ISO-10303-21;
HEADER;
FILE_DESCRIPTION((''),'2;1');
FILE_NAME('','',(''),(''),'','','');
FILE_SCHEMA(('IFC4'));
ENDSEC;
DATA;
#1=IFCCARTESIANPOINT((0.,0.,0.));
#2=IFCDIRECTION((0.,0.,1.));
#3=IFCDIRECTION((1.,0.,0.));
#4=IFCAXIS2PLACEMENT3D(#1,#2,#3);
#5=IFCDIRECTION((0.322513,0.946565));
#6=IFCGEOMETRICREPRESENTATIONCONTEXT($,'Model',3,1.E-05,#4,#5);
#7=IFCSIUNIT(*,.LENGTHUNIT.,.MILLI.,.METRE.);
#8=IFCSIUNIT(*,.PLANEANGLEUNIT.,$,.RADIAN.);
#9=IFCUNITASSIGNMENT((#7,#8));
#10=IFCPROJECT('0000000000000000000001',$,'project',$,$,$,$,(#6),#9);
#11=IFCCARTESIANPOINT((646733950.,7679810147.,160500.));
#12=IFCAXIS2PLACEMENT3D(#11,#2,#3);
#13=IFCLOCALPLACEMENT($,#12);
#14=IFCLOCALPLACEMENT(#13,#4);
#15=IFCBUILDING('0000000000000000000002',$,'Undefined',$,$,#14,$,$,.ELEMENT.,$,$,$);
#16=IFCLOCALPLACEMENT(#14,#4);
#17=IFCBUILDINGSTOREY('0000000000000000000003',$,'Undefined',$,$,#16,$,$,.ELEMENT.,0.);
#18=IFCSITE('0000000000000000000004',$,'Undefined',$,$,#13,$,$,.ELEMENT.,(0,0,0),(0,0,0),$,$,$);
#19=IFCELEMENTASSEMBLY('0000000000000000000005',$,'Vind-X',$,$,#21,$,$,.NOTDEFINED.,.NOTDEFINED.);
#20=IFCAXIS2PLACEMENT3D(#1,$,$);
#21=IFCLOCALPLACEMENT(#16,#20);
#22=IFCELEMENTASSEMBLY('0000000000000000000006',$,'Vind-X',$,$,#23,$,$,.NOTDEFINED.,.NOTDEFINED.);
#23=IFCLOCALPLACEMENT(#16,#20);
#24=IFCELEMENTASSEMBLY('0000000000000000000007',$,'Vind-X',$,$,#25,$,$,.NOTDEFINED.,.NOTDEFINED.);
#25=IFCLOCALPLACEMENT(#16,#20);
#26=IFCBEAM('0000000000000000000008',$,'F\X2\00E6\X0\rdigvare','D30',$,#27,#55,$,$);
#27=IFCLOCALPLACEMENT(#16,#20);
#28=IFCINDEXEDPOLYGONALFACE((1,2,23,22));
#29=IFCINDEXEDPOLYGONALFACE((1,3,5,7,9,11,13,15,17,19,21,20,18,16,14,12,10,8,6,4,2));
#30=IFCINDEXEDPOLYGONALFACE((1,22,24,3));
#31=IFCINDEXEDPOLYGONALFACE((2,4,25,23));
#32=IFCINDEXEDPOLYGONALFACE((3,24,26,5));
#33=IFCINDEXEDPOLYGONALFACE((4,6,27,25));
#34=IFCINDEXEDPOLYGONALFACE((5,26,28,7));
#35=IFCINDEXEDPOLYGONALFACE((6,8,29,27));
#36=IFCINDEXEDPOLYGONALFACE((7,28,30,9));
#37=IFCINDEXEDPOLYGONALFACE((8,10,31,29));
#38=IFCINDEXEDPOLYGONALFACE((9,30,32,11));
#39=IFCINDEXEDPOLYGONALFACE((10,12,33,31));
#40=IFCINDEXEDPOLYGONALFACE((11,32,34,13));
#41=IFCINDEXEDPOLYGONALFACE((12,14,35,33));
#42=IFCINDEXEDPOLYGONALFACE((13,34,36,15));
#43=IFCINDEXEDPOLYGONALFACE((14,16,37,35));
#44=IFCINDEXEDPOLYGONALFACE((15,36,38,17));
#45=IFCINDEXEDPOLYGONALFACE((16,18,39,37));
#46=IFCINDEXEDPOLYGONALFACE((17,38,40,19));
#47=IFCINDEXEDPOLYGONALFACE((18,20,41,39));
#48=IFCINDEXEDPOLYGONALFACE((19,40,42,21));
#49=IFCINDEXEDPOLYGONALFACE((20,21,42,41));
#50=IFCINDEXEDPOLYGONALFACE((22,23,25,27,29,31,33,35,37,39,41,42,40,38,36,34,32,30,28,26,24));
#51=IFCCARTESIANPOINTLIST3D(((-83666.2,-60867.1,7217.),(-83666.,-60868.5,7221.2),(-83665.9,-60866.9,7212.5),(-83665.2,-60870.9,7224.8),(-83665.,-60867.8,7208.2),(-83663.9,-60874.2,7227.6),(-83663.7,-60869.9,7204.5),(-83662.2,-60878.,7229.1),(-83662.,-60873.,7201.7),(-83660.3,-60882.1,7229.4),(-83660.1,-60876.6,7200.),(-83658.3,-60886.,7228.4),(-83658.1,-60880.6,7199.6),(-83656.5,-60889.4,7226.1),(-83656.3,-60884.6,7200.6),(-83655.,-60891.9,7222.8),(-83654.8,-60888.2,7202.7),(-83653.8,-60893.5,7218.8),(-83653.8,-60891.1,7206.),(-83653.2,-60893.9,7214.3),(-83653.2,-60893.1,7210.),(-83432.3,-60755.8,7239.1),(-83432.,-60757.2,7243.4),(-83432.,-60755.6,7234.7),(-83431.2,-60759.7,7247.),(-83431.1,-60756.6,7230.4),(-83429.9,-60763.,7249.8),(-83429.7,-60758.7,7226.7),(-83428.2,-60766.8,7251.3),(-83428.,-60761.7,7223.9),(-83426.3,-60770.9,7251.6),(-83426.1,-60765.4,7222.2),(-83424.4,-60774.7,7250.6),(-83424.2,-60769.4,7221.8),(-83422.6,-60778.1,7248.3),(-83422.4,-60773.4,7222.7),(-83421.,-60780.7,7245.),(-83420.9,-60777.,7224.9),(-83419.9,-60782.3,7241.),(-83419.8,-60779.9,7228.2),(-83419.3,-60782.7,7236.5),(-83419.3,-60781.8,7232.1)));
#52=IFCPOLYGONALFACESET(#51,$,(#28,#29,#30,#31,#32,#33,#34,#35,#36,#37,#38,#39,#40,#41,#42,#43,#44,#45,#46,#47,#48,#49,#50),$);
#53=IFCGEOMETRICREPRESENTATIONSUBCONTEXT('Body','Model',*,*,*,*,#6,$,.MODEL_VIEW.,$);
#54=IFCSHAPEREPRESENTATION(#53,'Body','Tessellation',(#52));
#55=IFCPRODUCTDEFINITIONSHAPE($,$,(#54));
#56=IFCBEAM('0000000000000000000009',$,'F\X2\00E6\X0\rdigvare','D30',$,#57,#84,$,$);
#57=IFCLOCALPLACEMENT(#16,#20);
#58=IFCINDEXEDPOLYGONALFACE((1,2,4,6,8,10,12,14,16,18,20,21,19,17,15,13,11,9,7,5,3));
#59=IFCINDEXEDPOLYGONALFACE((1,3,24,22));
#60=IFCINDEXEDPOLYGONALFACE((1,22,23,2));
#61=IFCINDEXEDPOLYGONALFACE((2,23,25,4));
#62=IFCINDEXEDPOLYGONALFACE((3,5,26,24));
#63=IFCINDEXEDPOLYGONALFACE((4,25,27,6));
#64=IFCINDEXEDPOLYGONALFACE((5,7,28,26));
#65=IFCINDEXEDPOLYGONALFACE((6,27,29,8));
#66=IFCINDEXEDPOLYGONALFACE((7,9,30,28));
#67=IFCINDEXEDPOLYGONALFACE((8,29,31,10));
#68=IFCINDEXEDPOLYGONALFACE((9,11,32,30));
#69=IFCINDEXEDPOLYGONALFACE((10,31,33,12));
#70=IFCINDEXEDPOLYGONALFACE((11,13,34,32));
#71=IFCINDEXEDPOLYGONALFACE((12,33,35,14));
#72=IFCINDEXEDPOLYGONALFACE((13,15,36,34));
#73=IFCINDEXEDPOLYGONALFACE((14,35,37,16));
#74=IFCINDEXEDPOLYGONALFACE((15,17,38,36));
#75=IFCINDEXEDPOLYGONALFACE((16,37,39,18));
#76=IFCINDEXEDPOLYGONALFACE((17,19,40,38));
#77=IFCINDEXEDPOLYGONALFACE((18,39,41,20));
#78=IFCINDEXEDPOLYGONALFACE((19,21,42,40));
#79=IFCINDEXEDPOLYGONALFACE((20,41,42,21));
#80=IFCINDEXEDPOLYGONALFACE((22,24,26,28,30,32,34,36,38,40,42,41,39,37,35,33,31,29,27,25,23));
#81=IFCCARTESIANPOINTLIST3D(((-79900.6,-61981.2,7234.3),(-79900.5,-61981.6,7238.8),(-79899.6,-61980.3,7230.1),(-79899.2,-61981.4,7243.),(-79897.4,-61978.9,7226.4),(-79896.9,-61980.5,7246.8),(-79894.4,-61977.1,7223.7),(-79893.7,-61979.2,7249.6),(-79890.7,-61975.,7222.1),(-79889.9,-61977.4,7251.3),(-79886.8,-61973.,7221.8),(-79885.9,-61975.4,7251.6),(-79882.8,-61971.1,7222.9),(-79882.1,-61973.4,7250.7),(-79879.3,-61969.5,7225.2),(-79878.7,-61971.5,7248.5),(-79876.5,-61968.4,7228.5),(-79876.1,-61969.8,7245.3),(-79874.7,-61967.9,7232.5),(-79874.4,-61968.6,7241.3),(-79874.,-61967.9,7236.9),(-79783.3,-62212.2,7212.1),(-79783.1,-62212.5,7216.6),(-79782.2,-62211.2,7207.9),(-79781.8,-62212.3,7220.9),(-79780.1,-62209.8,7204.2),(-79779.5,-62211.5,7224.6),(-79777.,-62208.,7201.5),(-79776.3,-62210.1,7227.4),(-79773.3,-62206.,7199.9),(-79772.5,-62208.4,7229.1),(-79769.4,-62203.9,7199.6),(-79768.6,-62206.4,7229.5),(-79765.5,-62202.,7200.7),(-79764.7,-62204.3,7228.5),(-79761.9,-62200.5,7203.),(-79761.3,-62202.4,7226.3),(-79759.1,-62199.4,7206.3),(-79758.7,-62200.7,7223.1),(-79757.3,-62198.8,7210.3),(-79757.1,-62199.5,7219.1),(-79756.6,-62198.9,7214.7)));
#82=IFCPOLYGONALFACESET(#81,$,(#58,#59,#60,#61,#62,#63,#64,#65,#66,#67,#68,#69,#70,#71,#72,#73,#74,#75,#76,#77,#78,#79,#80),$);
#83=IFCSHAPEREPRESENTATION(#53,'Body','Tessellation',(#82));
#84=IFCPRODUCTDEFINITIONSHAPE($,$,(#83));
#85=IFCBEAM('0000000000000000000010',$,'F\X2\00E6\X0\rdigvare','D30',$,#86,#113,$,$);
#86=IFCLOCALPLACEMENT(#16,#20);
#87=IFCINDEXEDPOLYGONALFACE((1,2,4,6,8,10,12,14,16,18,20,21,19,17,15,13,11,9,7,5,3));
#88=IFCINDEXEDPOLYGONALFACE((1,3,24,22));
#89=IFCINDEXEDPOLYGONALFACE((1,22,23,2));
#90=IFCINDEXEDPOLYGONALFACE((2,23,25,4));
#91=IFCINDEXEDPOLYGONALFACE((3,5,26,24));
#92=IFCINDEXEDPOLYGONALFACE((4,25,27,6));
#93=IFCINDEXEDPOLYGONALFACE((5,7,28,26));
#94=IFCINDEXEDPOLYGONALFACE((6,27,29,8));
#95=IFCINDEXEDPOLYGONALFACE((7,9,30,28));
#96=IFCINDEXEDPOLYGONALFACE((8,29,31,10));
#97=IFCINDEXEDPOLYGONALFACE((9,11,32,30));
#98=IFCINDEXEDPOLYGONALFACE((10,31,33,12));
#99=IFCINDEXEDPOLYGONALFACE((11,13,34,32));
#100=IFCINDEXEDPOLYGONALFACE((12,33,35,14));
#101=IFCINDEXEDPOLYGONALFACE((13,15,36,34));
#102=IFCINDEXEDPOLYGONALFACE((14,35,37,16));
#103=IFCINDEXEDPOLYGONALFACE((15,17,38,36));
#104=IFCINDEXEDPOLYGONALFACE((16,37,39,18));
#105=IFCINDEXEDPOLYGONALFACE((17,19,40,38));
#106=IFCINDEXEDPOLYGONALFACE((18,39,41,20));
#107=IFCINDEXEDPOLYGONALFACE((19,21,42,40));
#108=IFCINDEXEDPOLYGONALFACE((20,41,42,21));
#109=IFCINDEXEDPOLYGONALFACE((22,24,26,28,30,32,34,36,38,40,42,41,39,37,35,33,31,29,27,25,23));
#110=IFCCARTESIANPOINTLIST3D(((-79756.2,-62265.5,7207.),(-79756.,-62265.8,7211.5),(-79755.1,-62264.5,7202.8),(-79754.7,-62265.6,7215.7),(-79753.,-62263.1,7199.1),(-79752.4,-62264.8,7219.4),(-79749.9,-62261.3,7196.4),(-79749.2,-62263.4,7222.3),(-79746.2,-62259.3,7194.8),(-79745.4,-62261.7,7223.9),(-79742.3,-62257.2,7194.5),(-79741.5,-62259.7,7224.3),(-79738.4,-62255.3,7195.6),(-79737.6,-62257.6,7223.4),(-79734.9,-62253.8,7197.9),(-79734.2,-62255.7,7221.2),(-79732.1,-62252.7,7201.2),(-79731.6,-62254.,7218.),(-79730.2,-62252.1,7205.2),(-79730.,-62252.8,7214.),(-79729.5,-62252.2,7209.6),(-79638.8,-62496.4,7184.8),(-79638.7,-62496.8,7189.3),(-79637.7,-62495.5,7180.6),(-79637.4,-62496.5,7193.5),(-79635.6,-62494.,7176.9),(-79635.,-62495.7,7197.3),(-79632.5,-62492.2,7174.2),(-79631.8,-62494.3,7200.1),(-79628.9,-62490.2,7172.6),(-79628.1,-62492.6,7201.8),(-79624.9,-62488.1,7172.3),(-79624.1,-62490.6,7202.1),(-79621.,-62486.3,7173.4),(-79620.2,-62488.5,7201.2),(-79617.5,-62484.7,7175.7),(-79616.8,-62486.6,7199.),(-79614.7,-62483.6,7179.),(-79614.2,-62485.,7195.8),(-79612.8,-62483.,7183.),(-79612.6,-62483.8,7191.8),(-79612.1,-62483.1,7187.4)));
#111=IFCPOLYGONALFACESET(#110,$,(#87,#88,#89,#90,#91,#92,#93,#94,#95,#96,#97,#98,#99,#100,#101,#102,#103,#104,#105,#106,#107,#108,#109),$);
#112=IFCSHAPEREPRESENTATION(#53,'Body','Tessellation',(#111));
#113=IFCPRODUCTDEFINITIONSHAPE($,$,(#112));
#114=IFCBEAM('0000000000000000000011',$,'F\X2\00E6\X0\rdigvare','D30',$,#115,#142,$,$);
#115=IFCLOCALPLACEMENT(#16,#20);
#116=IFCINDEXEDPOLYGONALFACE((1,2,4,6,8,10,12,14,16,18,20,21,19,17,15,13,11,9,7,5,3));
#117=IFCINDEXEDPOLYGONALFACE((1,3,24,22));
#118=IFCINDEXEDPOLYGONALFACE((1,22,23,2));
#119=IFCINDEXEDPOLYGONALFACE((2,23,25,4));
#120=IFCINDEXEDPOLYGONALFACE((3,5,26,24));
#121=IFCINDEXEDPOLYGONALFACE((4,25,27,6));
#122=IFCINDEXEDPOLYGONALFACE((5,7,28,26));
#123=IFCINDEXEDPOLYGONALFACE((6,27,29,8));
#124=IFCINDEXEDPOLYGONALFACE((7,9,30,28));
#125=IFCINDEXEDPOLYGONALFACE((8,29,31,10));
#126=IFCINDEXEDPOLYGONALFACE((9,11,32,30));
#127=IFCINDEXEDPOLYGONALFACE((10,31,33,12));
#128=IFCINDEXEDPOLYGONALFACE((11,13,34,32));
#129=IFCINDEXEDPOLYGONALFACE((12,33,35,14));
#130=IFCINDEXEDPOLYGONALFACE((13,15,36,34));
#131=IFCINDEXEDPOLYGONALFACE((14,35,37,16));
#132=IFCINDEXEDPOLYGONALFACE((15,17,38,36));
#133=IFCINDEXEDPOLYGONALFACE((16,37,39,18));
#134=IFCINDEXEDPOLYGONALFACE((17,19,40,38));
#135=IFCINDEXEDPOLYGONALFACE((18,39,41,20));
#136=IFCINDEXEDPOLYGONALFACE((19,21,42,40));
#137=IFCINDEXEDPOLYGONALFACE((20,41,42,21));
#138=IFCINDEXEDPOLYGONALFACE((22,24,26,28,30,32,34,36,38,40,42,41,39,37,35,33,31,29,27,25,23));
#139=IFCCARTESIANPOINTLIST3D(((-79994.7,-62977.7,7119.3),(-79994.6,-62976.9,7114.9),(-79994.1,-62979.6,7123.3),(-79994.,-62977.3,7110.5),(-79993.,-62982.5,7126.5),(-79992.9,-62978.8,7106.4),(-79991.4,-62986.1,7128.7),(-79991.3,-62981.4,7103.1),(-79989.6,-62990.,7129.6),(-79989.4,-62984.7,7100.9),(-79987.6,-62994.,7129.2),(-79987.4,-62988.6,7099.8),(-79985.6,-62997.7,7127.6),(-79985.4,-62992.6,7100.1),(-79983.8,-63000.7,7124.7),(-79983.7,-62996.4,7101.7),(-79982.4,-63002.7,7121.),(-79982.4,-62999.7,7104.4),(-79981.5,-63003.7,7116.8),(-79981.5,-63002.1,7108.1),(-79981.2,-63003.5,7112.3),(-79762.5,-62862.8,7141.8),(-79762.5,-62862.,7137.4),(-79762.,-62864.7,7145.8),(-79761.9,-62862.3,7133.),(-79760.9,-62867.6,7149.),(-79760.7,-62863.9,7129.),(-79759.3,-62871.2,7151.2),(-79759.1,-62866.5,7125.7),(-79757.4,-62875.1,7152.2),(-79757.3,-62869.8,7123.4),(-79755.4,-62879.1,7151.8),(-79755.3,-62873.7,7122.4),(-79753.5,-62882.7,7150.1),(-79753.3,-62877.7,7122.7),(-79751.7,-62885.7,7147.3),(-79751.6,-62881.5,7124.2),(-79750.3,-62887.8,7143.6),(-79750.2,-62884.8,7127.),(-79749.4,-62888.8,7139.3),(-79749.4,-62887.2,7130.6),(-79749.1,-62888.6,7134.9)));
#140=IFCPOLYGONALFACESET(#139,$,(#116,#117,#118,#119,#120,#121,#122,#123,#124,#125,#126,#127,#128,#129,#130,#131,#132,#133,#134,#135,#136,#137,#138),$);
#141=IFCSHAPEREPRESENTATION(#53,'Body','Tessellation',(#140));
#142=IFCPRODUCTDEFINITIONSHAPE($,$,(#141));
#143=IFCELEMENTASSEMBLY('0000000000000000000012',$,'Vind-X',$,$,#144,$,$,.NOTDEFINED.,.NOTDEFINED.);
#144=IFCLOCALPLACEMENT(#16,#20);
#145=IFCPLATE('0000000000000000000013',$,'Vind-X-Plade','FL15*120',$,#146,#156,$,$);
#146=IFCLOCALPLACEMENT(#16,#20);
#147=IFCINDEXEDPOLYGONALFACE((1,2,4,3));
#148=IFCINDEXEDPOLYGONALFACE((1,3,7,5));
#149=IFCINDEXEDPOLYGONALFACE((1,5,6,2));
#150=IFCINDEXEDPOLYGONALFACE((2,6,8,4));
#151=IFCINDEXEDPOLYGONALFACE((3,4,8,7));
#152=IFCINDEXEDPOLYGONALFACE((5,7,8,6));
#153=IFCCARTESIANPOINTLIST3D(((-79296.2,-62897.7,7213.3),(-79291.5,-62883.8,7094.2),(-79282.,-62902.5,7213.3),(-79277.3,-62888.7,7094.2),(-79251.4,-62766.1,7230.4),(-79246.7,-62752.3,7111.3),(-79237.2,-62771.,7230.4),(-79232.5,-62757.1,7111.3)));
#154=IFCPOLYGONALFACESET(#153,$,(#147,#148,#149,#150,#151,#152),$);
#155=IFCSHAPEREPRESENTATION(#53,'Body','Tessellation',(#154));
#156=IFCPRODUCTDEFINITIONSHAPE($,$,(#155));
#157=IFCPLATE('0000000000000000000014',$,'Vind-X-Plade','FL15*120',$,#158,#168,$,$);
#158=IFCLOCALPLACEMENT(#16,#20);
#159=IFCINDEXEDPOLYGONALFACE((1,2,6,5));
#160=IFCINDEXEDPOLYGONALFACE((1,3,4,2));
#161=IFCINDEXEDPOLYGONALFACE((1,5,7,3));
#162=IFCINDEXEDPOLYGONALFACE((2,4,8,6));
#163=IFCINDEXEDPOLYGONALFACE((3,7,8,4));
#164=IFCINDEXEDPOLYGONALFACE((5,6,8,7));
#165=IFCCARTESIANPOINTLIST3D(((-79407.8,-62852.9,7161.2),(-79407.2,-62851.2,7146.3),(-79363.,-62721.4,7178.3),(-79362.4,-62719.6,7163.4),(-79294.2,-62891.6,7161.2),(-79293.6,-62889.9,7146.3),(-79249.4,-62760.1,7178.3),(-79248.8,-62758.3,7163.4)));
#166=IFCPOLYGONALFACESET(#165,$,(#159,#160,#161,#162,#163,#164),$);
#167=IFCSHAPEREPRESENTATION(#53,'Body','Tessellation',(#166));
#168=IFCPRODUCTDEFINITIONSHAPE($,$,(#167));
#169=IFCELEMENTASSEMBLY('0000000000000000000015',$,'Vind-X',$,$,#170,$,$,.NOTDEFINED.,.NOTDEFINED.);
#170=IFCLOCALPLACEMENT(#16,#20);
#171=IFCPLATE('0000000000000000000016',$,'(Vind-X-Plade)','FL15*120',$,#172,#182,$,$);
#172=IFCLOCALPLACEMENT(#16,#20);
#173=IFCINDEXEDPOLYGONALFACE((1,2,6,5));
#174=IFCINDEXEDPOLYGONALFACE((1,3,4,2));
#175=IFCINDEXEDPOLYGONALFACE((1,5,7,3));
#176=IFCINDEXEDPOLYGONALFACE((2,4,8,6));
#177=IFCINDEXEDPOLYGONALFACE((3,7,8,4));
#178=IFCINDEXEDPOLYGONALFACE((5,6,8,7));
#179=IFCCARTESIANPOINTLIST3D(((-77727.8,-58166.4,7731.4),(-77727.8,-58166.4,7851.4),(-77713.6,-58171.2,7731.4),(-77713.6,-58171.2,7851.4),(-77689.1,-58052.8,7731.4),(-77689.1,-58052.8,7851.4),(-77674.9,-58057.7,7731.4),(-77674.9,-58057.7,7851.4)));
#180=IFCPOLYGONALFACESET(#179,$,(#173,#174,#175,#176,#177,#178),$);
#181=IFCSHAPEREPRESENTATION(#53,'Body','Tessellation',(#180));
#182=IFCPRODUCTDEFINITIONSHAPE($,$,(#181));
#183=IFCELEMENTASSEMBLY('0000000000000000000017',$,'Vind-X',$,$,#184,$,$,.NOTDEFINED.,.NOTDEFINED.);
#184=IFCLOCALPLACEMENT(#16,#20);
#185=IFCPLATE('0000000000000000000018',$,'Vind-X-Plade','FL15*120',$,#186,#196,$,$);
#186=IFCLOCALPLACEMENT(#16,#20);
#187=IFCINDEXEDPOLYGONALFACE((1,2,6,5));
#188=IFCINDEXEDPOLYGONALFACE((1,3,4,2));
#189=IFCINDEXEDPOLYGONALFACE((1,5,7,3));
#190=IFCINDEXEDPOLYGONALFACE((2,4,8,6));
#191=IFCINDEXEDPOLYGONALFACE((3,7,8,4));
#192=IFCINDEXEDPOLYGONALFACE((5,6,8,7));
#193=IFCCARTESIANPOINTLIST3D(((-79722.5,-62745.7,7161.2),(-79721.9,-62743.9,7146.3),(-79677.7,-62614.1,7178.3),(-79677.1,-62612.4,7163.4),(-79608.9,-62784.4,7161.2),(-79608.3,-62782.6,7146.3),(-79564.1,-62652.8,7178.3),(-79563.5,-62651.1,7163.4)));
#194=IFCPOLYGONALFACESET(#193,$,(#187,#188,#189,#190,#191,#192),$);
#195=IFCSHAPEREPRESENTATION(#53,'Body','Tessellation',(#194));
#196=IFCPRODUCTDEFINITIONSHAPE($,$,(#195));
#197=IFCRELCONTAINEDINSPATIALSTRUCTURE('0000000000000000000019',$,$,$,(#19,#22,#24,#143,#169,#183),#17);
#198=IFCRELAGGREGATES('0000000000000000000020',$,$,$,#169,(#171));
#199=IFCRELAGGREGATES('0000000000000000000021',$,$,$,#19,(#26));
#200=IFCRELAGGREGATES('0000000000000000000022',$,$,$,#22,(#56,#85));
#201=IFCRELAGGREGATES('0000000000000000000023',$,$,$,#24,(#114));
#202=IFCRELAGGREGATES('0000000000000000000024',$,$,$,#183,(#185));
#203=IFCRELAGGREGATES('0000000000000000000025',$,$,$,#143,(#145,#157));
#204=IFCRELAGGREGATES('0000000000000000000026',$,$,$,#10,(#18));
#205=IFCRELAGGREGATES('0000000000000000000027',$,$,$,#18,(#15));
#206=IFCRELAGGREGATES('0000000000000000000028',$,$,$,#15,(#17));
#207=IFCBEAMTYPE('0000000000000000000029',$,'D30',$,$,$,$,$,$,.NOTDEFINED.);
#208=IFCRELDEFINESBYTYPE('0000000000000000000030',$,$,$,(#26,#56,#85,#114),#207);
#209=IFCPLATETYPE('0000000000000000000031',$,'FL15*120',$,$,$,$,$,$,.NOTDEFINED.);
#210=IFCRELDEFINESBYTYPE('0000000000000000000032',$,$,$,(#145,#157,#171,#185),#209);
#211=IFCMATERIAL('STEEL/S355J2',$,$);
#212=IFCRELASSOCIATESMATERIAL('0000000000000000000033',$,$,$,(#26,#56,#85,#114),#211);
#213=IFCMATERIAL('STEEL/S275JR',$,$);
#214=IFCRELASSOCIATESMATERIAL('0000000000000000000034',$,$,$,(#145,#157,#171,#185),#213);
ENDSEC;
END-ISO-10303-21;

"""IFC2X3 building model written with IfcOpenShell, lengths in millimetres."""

from ifc_helpers import new_model, si_unit, direction, frame, origin_with_axes, origin_2d_with_axis, place, context, subcontext, project, spatial, polyline, circle, outline, extrude, material, type_object, element, aggregate, save


model = new_model("IFC2X3")

# Units and contexts
model_context = context("Model", 3, precision=1e-05, world=origin_with_axes(), true_north=direction((0.322513, 0.946565)))
body_context = subcontext(model_context, "Body", "Model", "MODEL_VIEW")
ifc_project = project(units=[si_unit("LENGTHUNIT", "METRE", prefix="MILLI"), si_unit("PLANEANGLEUNIT", "RADIAN")], contexts=[model_context])

# Site, building, storey
site_placement = place(None, frame((646733950.0, 7679810147.0, 160500.0), z_axis=(0.0, 0.0, 1.0), x_axis=(1.0, 0.0, 0.0)))
site = spatial("IfcSite", under=ifc_project, at=site_placement, Name="Undefined", CompositionType="ELEMENT", RefLatitude=(0, 0, 0), RefLongitude=(0, 0, 0))
building_placement = place(site_placement, origin_with_axes())
building = spatial("IfcBuilding", under=site, at=building_placement, Name="Undefined", CompositionType="ELEMENT")
storey_placement = place(building_placement, origin_with_axes())
storey = spatial("IfcBuildingStorey", under=building, at=storey_placement, Name="Undefined", CompositionType="ELEMENT", Elevation=0.0)

# Element assemblies
assembly_1_placement = place(storey_placement, origin_with_axes())
assembly_1 = element("IfcElementAssembly", 1, at=assembly_1_placement, inside=storey, Name="Vind-X", AssemblyPlace="NOTDEFINED", PredefinedType="NOTDEFINED")
ifc_material_1 = material(Name="STEEL/S355J2")
assembly_2_placement = place(storey_placement, origin_with_axes())
assembly_2 = element("IfcElementAssembly", 2, at=assembly_2_placement, inside=storey, Name="Vind-X", AssemblyPlace="NOTDEFINED", PredefinedType="NOTDEFINED")

# Element assembly
assembly_3_placement = place(storey_placement, origin_with_axes())
assembly_3 = element("IfcElementAssembly", 3, at=assembly_3_placement, inside=storey, Name="Vind-X", AssemblyPlace="NOTDEFINED", PredefinedType="NOTDEFINED")

# Beams
beam_type_1 = type_object("IfcBeamType", Name="D30", PredefinedType="NOTDEFINED")
beam_1_placement = place(assembly_1_placement, frame((-83659.7, -60880.3, 7214.5), z_axis=(-0.434441, 0.89649, 0.08699), x_axis=(0.899842, 0.427784, 0.085352)))
beam_1 = element("IfcBeam", 4, at=beam_1_placement, type_object=beam_type_1, material=ifc_material_1, Name="Færdigvare", Description="D30", context=body_context, shape_type="SweptSolid", body=[
    extrude(circle(Radius=15.0, at=origin_2d_with_axis()), frame((260.0, 0.0, 0.0), z_axis=(-1.0, 0.0, 0.0), x_axis=(0.0, -1.0, 0.0)), (0.0, 0.0, 1.0), 260.0),
])
beam_2_placement = place(assembly_2_placement, frame((-79770.0, -62205.7, 7214.5), z_axis=(0.891425, 0.444742, 0.08699), x_axis=(-0.451461, 0.888199, 0.085352)))
beam_2 = element("IfcBeam", 5, at=beam_2_placement, type_object=beam_type_1, material=ifc_material_1, Name="Færdigvare", Description="D30", context=body_context, shape_type="SweptSolid", body=[
    extrude(circle(Radius=15.0, at=origin_2d_with_axis()), frame((260.0, 0.0, 0.0), z_axis=(-1.0, 0.0, 0.0), x_axis=(0.0, -1.0, 0.0)), (0.0, 0.0, 1.0), 260.0),
])
beam_3_placement = place(assembly_2_placement, frame((-79625.5, -62489.9, 7187.2), z_axis=(0.891424, 0.444742, 0.08699), x_axis=(-0.451462, 0.888199, 0.085352)))
beam_3 = element("IfcBeam", 6, at=beam_3_placement, type_object=beam_type_1, material=ifc_material_1, Name="Færdigvare", Description="D30", context=body_context, shape_type="SweptSolid", body=[
    extrude(circle(Radius=15.0, at=origin_2d_with_axis()), frame((260.0, 0.0, 0.0), z_axis=(-1.0, 0.0, 0.0), x_axis=(0.0, -1.0, 0.0)), (0.0, 0.0, 1.0), 260.0),
])
beam_4_placement = place(assembly_3_placement, frame((-79755.8, -62875.4, 7137.3), z_axis=(-0.448662, 0.88959, 0.085625), x_axis=(-0.892837, -0.441952, -0.086721)))
beam_4 = element("IfcBeam", 7, at=beam_4_placement, type_object=beam_type_1, material=ifc_material_1, Name="Færdigvare", Description="D30", context=body_context, shape_type="SweptSolid", body=[
    extrude(circle(Radius=15.0, at=origin_2d_with_axis()), frame((260.0, 0.0, 0.0), z_axis=(-1.0, 0.0, 0.0), x_axis=(0.0, -1.0, 0.0)), (0.0, 0.0, 1.0), 260.0),
])

# Element assembly
assembly_4_placement = place(storey_placement, origin_with_axes())
assembly_4 = element("IfcElementAssembly", 8, at=assembly_4_placement, inside=storey, Name="Vind-X", AssemblyPlace="NOTDEFINED", PredefinedType="NOTDEFINED")

# Plates
ifc_material_2 = material(Name="STEEL/S275JR")
plate_type_1 = type_object("IfcPlateType", Name="FL15*120", PredefinedType="NOTDEFINED")
plate_1_placement = place(assembly_4_placement, frame((-79239.6, -62754.7, 7111.3), z_axis=(-0.946565, 0.322513, 0.0), x_axis=(-0.320109, -0.93951, -0.121869)))
plate_1 = element("IfcPlate", 9, at=plate_1_placement, type_object=plate_type_1, material=ifc_material_2, Name="Vind-X-Plade", Description="FL15*120", context=body_context, shape_type="SweptSolid", body=[
    extrude(outline(polyline([(0.0, 0.0), (140.0, 0.0), (140.0, 120.0), (0.0, 120.0), (0.0, 0.0)])), frame((0.0, 0.0, -7.5), z_axis=(0.0, 0.0, 1.0), x_axis=(1.0, 0.0, 0.0)), (0.0, 0.0, 1.0), 15.0),
])
plate_2_placement = place(assembly_4_placement, frame((-79385.1, -62786.3, 7162.3), z_axis=(0.039304, 0.115357, -0.992546), x_axis=(0.946565, -0.322513, 0.0)))
plate_2 = element("IfcPlate", 10, at=plate_2_placement, type_object=plate_type_1, material=ifc_material_2, Name="Vind-X-Plade", Description="FL15*120", context=body_context, shape_type="SweptSolid", body=[
    extrude(outline(polyline([(0.0, -70.0), (0.0, 70.0), (120.0, 70.0), (120.0, -70.0), (0.0, -70.0)])), frame((0.0, 0.0, -7.5), z_axis=(0.0, 0.0, 1.0), x_axis=(1.0, 0.0, 0.0)), (0.0, 0.0, 1.0), 15.0),
])

# Element assemblies, plates
assembly_5_placement = place(storey_placement, origin_with_axes())
assembly_5 = element("IfcElementAssembly", 11, at=assembly_5_placement, inside=storey, Name="Vind-X", AssemblyPlace="NOTDEFINED", PredefinedType="NOTDEFINED")
plate_3_placement = place(assembly_5_placement, frame((-77720.7, -58168.8, 7851.4), z_axis=(-0.946565, 0.322513, 0.0), x_axis=(0.322513, 0.946565, 0.0)))
plate_3 = element("IfcPlate", 12, at=plate_3_placement, type_object=plate_type_1, material=ifc_material_2, Name="(Vind-X-Plade)", Description="FL15*120", context=body_context, shape_type="SweptSolid", body=[
    extrude(outline(polyline([(0.0, 0.0), (120.0, 0.0), (120.0, 120.0), (0.0, 120.0), (0.0, 0.0)])), frame((0.0, 0.0, -7.5), z_axis=(0.0, 0.0, 1.0), x_axis=(1.0, 0.0, 0.0)), (0.0, 0.0, 1.0), 15.0),
])
assembly_6_placement = place(storey_placement, origin_with_axes())
assembly_6 = element("IfcElementAssembly", 13, at=assembly_6_placement, inside=storey, Name="Vind-X", AssemblyPlace="NOTDEFINED", PredefinedType="NOTDEFINED")
plate_4_placement = place(assembly_6_placement, frame((-79586.2, -62717.7, 7162.3), z_axis=(0.039304, 0.115357, -0.992546), x_axis=(-0.946565, 0.322513, 0.0)))
plate_4 = element("IfcPlate", 14, at=plate_4_placement, type_object=plate_type_1, material=ifc_material_2, Name="Vind-X-Plade", Description="FL15*120", context=body_context, shape_type="SweptSolid", body=[
    extrude(outline(polyline([(0.0, -70.0), (0.0, 70.0), (120.0, 70.0), (120.0, -70.0), (0.0, -70.0)])), frame((0.0, 0.0, -7.5), z_axis=(0.0, 0.0, 1.0), x_axis=(1.0, 0.0, 0.0)), (0.0, 0.0, 1.0), 15.0),
])

aggregate(assembly_5, [plate_3])

aggregate(assembly_1, [beam_1])
aggregate(assembly_2, [beam_2, beam_3])
aggregate(assembly_3, [beam_4])
aggregate(assembly_6, [plate_4])
aggregate(assembly_4, [plate_1, plate_2])

save(model, "model.ifc")
